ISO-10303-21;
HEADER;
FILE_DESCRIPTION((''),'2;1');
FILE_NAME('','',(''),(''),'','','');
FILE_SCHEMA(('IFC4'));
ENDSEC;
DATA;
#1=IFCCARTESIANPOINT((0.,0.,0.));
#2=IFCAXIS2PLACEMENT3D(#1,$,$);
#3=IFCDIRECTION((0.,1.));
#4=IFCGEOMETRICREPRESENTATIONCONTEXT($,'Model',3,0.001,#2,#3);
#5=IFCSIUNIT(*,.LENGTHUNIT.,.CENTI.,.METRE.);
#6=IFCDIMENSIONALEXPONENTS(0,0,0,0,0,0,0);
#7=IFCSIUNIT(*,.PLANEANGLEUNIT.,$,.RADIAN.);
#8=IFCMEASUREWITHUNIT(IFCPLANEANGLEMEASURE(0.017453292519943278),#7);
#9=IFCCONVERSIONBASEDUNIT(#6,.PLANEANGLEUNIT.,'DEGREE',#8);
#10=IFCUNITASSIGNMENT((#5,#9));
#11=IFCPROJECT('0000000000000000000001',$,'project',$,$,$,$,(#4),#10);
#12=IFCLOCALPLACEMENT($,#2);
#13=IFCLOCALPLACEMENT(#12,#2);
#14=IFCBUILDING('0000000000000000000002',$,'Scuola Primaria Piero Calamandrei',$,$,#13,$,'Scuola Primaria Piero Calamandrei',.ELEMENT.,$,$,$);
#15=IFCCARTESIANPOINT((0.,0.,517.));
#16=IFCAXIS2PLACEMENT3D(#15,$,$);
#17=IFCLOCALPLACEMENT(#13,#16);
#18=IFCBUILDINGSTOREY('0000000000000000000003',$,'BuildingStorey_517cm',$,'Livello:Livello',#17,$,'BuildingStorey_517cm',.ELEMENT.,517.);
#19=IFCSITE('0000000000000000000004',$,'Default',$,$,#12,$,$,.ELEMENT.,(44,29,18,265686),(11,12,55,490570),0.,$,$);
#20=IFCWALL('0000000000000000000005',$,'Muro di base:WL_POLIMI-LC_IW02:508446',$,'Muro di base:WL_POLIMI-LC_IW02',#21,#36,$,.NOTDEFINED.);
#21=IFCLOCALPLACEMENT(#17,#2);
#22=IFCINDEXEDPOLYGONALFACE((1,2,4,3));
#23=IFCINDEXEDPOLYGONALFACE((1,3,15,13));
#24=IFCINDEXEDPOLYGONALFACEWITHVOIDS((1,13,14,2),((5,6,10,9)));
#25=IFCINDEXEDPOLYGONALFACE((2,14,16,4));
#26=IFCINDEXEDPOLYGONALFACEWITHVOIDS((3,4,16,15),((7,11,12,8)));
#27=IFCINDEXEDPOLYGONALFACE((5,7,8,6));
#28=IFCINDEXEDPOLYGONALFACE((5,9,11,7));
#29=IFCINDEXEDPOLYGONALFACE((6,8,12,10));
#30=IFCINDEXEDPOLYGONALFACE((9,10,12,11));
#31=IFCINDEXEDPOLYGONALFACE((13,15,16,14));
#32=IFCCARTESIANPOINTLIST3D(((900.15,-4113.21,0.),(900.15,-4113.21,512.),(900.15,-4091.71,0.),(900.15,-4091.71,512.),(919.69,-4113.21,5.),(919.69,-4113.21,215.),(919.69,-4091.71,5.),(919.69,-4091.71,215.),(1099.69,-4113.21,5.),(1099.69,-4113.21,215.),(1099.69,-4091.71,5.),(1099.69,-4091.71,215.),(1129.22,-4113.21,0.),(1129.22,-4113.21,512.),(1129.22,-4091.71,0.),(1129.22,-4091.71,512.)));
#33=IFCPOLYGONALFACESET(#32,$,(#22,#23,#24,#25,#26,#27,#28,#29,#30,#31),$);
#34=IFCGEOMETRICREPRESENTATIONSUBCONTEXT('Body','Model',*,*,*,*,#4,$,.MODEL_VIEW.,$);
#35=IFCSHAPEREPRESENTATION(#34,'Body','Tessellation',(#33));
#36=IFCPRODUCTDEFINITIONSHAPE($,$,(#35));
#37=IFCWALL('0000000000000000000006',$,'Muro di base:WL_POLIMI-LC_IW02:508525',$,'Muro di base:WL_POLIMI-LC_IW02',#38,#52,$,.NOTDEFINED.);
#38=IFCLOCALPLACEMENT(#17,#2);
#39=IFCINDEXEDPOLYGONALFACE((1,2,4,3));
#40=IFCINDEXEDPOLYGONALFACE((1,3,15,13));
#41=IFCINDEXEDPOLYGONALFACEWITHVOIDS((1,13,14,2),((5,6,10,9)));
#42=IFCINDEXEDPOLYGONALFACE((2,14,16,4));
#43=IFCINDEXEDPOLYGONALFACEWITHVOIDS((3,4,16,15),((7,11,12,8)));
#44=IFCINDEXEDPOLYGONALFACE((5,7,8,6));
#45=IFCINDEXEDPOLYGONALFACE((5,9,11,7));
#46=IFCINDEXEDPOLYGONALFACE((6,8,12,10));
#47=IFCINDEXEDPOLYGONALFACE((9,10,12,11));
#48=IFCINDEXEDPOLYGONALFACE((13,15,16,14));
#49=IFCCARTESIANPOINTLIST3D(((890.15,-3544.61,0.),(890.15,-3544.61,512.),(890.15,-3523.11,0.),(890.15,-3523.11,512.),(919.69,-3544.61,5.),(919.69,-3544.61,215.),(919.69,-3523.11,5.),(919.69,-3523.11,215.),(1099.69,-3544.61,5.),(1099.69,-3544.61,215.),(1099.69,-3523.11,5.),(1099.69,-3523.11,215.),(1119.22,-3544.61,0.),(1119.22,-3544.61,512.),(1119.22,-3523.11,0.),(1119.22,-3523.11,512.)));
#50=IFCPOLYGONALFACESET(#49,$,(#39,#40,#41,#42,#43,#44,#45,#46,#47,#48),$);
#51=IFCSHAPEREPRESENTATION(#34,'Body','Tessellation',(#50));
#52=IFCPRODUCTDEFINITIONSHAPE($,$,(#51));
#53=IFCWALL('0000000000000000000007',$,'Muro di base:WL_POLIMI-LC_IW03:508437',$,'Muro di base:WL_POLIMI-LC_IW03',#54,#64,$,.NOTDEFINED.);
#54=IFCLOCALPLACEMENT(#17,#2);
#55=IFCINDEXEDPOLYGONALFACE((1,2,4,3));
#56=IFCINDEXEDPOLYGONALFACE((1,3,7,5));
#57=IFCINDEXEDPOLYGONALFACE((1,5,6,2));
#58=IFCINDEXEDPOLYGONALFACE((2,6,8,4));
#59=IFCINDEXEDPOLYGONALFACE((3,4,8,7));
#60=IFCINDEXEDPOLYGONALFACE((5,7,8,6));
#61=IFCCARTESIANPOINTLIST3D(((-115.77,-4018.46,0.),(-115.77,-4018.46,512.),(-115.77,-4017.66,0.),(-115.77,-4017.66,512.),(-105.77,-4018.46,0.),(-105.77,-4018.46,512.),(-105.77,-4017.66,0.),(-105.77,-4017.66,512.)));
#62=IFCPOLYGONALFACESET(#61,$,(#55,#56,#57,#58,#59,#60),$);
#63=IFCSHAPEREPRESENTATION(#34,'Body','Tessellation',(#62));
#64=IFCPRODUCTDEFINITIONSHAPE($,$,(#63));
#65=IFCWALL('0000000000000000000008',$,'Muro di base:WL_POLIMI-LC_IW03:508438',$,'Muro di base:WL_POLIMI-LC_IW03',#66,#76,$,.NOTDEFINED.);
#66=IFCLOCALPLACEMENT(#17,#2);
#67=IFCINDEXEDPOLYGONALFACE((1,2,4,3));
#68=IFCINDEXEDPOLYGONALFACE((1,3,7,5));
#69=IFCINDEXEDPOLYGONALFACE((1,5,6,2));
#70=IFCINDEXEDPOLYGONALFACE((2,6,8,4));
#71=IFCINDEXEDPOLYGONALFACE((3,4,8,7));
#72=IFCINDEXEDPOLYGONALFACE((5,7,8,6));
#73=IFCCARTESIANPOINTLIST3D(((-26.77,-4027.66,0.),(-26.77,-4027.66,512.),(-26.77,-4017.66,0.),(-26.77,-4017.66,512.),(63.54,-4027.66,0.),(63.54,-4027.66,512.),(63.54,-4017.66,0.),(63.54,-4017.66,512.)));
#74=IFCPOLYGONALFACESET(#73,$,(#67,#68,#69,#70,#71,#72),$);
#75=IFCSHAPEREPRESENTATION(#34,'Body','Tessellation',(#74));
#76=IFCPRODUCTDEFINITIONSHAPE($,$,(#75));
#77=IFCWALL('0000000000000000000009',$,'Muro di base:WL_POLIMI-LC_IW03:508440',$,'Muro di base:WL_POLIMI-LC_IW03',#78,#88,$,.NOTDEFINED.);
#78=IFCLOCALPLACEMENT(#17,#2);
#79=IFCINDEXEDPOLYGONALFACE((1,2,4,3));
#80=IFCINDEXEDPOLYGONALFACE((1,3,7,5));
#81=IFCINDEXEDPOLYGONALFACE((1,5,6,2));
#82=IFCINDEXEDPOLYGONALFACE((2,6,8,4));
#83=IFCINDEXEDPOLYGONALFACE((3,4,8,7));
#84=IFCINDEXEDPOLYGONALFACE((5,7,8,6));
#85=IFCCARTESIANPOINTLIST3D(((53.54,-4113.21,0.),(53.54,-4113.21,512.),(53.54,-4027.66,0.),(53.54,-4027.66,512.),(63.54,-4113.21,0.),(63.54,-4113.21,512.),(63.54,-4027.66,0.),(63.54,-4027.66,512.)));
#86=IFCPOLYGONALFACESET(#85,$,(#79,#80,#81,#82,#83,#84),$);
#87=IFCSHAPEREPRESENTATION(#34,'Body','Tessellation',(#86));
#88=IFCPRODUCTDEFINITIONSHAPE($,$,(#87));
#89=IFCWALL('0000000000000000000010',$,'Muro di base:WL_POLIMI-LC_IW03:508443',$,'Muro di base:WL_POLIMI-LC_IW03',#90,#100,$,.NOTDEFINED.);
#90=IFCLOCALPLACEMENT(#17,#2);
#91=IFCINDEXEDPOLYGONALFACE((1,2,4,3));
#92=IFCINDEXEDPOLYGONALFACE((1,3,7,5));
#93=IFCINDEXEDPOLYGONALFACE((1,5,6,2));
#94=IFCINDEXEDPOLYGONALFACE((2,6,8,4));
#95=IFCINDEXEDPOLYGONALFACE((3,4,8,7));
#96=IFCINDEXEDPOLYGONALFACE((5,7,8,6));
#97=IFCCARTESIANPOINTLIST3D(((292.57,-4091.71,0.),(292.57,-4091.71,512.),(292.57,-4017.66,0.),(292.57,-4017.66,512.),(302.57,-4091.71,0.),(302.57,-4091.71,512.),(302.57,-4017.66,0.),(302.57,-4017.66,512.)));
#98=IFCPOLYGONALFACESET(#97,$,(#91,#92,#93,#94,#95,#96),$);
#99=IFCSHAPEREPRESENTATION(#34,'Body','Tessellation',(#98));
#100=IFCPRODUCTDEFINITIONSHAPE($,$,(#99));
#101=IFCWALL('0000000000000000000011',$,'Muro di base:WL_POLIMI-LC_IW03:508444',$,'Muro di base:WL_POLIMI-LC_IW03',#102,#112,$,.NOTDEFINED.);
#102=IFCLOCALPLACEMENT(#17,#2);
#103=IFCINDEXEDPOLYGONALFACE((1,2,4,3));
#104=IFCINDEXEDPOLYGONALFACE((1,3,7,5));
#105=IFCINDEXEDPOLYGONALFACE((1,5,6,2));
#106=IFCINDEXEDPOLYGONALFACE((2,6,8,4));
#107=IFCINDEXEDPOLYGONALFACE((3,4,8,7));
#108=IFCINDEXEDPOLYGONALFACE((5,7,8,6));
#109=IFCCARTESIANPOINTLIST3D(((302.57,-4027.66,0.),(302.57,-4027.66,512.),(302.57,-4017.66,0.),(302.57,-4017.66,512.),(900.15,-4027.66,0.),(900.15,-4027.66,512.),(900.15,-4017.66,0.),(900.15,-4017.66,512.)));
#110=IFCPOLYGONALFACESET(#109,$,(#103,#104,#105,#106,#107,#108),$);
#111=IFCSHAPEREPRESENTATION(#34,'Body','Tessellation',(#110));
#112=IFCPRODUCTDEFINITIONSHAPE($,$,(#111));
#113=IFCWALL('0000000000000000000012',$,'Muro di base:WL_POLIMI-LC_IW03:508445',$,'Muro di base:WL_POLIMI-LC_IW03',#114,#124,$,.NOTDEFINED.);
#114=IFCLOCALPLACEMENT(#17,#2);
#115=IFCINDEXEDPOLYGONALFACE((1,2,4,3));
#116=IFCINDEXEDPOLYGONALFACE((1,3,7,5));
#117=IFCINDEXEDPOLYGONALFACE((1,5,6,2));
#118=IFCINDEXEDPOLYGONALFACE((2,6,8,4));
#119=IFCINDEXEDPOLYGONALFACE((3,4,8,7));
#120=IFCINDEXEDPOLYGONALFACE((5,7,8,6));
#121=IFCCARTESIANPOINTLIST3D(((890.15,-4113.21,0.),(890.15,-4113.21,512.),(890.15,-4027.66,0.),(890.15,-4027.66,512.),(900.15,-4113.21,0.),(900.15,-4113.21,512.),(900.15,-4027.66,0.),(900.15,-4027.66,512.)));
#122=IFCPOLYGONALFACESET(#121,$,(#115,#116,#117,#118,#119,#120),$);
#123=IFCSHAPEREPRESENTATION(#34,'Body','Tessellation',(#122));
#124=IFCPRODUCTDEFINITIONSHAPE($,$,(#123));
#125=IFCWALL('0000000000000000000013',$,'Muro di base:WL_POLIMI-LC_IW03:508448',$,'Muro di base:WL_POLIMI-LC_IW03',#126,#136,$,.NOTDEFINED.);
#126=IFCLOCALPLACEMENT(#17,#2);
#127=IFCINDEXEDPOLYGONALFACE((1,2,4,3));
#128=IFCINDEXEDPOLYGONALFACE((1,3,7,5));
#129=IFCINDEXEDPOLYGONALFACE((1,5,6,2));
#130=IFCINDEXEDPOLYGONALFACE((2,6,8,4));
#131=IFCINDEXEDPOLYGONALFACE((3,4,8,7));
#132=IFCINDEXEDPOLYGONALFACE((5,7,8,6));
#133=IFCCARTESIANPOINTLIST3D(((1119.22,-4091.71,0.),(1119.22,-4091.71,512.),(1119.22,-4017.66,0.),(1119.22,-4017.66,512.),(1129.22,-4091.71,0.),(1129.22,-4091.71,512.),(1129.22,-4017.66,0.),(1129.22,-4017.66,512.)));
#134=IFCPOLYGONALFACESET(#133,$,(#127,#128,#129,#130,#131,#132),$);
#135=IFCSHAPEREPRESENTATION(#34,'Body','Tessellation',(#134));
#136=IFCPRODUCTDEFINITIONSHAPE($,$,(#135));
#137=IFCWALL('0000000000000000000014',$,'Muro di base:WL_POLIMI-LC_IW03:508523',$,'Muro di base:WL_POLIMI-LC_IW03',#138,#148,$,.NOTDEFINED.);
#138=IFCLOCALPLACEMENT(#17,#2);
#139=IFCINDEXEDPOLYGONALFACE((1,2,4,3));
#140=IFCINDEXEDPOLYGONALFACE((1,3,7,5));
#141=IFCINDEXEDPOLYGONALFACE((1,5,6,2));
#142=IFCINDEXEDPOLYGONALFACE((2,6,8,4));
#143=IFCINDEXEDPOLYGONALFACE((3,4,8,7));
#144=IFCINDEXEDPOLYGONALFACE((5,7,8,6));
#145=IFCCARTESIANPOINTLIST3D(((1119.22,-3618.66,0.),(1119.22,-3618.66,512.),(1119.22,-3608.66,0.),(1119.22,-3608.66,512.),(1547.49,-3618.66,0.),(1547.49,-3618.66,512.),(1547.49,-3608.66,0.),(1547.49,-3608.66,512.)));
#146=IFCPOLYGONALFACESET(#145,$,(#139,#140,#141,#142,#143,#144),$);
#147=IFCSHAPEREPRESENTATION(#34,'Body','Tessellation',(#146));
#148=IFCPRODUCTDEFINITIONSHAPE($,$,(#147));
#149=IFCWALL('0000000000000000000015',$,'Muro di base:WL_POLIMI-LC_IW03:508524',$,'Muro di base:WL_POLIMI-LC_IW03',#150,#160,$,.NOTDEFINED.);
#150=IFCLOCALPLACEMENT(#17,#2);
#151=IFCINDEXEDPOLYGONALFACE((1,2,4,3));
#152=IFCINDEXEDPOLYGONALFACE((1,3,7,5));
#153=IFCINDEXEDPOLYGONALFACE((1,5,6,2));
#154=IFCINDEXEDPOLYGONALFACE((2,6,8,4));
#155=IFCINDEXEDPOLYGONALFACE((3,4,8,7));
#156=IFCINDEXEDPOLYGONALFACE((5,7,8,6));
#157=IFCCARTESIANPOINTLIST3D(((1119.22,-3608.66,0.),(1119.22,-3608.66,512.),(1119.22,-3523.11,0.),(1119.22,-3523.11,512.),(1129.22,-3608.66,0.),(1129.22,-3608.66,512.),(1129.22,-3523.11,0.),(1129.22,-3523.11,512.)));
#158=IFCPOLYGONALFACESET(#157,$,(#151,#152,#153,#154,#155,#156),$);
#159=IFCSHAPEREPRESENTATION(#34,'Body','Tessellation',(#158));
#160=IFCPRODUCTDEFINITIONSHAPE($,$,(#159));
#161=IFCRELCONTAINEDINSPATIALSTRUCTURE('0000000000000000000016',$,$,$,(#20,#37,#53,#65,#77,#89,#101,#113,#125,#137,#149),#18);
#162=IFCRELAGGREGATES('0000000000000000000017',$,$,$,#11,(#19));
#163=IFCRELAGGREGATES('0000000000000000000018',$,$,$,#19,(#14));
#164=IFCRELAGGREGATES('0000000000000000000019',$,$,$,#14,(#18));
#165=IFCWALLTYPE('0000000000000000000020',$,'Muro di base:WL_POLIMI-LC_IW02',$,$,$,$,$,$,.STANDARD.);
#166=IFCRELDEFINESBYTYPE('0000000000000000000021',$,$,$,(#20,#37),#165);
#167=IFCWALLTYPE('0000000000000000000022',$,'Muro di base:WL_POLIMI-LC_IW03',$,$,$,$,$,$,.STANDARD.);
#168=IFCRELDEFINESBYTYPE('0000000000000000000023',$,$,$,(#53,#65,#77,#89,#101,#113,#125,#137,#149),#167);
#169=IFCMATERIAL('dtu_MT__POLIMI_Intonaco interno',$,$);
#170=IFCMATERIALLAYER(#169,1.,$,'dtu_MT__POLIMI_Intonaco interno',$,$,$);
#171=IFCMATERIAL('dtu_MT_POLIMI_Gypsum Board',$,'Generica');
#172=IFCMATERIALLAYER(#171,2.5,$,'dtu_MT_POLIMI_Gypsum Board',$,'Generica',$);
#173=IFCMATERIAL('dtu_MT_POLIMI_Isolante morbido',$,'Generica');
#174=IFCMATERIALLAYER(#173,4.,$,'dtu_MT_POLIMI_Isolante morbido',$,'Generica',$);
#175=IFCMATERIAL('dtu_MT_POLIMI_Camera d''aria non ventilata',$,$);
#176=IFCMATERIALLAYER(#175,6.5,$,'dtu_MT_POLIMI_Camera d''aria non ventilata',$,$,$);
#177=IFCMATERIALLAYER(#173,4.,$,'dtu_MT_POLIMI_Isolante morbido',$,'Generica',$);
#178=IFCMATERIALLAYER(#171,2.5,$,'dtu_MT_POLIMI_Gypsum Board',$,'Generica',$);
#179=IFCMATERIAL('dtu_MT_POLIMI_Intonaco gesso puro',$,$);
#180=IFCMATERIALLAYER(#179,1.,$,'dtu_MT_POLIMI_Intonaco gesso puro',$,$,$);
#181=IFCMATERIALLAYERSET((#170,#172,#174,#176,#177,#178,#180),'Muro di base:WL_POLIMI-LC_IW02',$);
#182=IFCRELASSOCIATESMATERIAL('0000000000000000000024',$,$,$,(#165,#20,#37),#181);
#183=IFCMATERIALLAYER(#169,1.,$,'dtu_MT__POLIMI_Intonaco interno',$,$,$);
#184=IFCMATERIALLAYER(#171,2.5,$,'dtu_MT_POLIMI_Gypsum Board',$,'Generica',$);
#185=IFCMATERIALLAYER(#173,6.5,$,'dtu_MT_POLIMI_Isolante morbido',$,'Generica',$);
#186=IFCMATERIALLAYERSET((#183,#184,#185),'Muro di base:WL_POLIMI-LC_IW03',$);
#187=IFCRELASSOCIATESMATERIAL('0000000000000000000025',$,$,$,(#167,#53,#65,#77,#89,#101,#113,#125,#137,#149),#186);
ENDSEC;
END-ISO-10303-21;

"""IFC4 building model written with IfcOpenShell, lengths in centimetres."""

from ifc_helpers import new_model, entity, si_unit, converted_unit, direction, frame, frame_2d, origin, place, context, subcontext, project, spatial, rectangle, extrude, material, layer, layer_set, layer_usage, type_object, element, save


model = new_model("IFC4")

# Units and contexts
model_context = context("Model", 3, precision=0.001, world=origin(), true_north=direction((0.0, 1.0)))
body_context = subcontext(model_context, "Body", "Model", "MODEL_VIEW")
ifc_project = project(units=[si_unit("LENGTHUNIT", "METRE", prefix="CENTI"), converted_unit("PLANEANGLEUNIT", "DEGREE", entity("IfcPlaneAngleMeasure", 0.017453292519943278), si_unit("PLANEANGLEUNIT", "RADIAN"), dimensions=[0, 0, 0, 0, 0, 0, 0])], contexts=[model_context])

# Site, building, storey
site_placement = place(None, origin())
site = spatial("IfcSite", under=ifc_project, at=site_placement, Name="Default", CompositionType="ELEMENT", RefLatitude=(44, 29, 18, 265686), RefLongitude=(11, 12, 55, 490570), RefElevation=0.0)
building_placement = place(site_placement, origin())
building = spatial("IfcBuilding", under=site, at=building_placement, Name="Scuola Primaria Piero Calamandrei", LongName="Scuola Primaria Piero Calamandrei", CompositionType="ELEMENT")
storey_placement = place(building_placement, frame((0.0, 0.0, 517.0)))
storey = spatial("IfcBuildingStorey", under=building, at=storey_placement, Name="BuildingStorey_517cm", ObjectType="Livello:Livello", LongName="BuildingStorey_517cm", CompositionType="ELEMENT", Elevation=517.0)

# Shared definitions
ifc_material_1 = material(Name="dtu_MT__POLIMI_Intonaco interno")

# Shared definitions
ifc_material_2 = material(Name="dtu_MT_POLIMI_Isolante morbido", Category="Generica")
ifc_material_3 = material(Name="dtu_MT_POLIMI_Gypsum Board", Category="Generica")

# Walls, openings
ifc_layer_1 = layer(ifc_material_1, 1.0, Name="dtu_MT__POLIMI_Intonaco interno")
ifc_layer_2 = layer(ifc_material_3, 2.5, Name="dtu_MT_POLIMI_Gypsum Board", Category="Generica")
ifc_layer_3 = layer(ifc_material_2, 4.0, Name="dtu_MT_POLIMI_Isolante morbido", Category="Generica")
ifc_material_4 = material(Name="dtu_MT_POLIMI_Camera d'aria non ventilata")
ifc_layer_4 = layer(ifc_material_4, 6.5, Name="dtu_MT_POLIMI_Camera d'aria non ventilata")
ifc_layer_5 = layer(ifc_material_2, 4.0, Name="dtu_MT_POLIMI_Isolante morbido", Category="Generica")
ifc_layer_6 = layer(ifc_material_3, 2.5, Name="dtu_MT_POLIMI_Gypsum Board", Category="Generica")
ifc_material_5 = material(Name="dtu_MT_POLIMI_Intonaco gesso puro")
ifc_layer_7 = layer(ifc_material_5, 1.0, Name="dtu_MT_POLIMI_Intonaco gesso puro")
ifc_layer_set_1 = layer_set([ifc_layer_1, ifc_layer_2, ifc_layer_3, ifc_layer_4, ifc_layer_5, ifc_layer_6, ifc_layer_7], Name="Muro di base:WL_POLIMI-LC_IW02")
wall_type_1 = type_object("IfcWallType", Name="Muro di base:WL_POLIMI-LC_IW02", PredefinedType="STANDARD", material=ifc_layer_set_1)
ifc_layer_usage_1 = layer_usage(ifc_layer_set_1, "AXIS2", "NEGATIVE", 10.75)
wall_1_placement = place(storey_placement, frame((1129.22, -4102.46, 0.0), z_axis=(0.0, 0.0, 1.0), x_axis=(-1.0, 0.0, 0.0)))
wall_1 = element("IfcWall", 1, at=wall_1_placement, inside=storey, type_object=wall_type_1, material=ifc_layer_usage_1, Name="Muro di base:WL_POLIMI-LC_IW02:508446", ObjectType="Muro di base:WL_POLIMI-LC_IW02", PredefinedType="NOTDEFINED", context=body_context, shape_type="SweptSolid", body=[
    extrude(rectangle(XDim=229.07, YDim=21.5, at=frame_2d((114.54, 0.0), x_axis=(-1.0, 0.0))), origin(), (0.0, 0.0, 1.0), 512.0),
])
opening_1_placement = place(wall_1_placement, frame((209.54, 10.75, 5.0)))
element("IfcOpeningElement", 2, at=opening_1_placement, cuts=wall_1, PredefinedType="OPENING", context=body_context, shape_type="SweptSolid", body=[
    extrude(rectangle(XDim=210.0, YDim=180.0, at=frame_2d((105.0, 90.0), x_axis=(-1.0, 0.0))), frame((0.0, 0.0, 0.0), z_axis=(0.0, -1.0, 0.0), x_axis=(0.0, 0.0, 1.0)), (0.0, 0.0, 1.0), 21.5),
])
ifc_layer_usage_2 = layer_usage(ifc_layer_set_1, "AXIS2", "NEGATIVE", 10.75)
wall_2_placement = place(storey_placement, frame((890.15, -3533.86, 0.0)))
wall_2 = element("IfcWall", 3, at=wall_2_placement, inside=storey, type_object=wall_type_1, material=ifc_layer_usage_2, Name="Muro di base:WL_POLIMI-LC_IW02:508525", ObjectType="Muro di base:WL_POLIMI-LC_IW02", PredefinedType="NOTDEFINED", context=body_context, shape_type="SweptSolid", body=[
    extrude(rectangle(XDim=229.07, YDim=21.5, at=frame_2d((114.54, 0.0), x_axis=(-1.0, 0.0))), origin(), (0.0, 0.0, 1.0), 512.0),
])
opening_2_placement = place(wall_2_placement, frame((209.54, 10.75, 5.0)))
element("IfcOpeningElement", 4, at=opening_2_placement, cuts=wall_2, PredefinedType="OPENING", context=body_context, shape_type="SweptSolid", body=[
    extrude(rectangle(XDim=210.0, YDim=180.0, at=frame_2d((105.0, 90.0), x_axis=(-1.0, 0.0))), frame((0.0, 0.0, 0.0), z_axis=(0.0, -1.0, 0.0), x_axis=(0.0, 0.0, 1.0)), (0.0, 0.0, 1.0), 21.5),
])

# Walls
ifc_layer_8 = layer(ifc_material_1, 1.0, Name="dtu_MT__POLIMI_Intonaco interno")
ifc_layer_9 = layer(ifc_material_3, 2.5, Name="dtu_MT_POLIMI_Gypsum Board", Category="Generica")
ifc_layer_10 = layer(ifc_material_2, 6.5, Name="dtu_MT_POLIMI_Isolante morbido", Category="Generica")
ifc_layer_set_2 = layer_set([ifc_layer_8, ifc_layer_9, ifc_layer_10], Name="Muro di base:WL_POLIMI-LC_IW03")
ifc_layer_usage_3 = layer_usage(ifc_layer_set_2, "AXIS2", "NEGATIVE", 5.0)
wall_type_2 = type_object("IfcWallType", Name="Muro di base:WL_POLIMI-LC_IW03", PredefinedType="STANDARD", material=ifc_layer_set_2)
wall_3_placement = place(storey_placement, frame((-110.77, -4017.66, 0.0), z_axis=(0.0, 0.0, 1.0), x_axis=(0.0, -1.0, 0.0)))
element("IfcWall", 5, at=wall_3_placement, inside=storey, type_object=wall_type_2, material=ifc_layer_usage_3, Name="Muro di base:WL_POLIMI-LC_IW03:508437", ObjectType="Muro di base:WL_POLIMI-LC_IW03", PredefinedType="NOTDEFINED", context=body_context, shape_type="SweptSolid", body=[
    extrude(rectangle(XDim=0.8, YDim=10.0, at=frame_2d((0.4, 0.0), x_axis=(-1.0, 0.0))), origin(), (0.0, 0.0, 1.0), 512.0),
])
ifc_layer_usage_4 = layer_usage(ifc_layer_set_2, "AXIS2", "NEGATIVE", 5.0)
wall_4_placement = place(storey_placement, frame((63.54, -4022.66, 0.0), z_axis=(0.0, 0.0, 1.0), x_axis=(-1.0, 0.0, 0.0)))
element("IfcWall", 6, at=wall_4_placement, inside=storey, type_object=wall_type_2, material=ifc_layer_usage_4, Name="Muro di base:WL_POLIMI-LC_IW03:508438", ObjectType="Muro di base:WL_POLIMI-LC_IW03", PredefinedType="NOTDEFINED", context=body_context, shape_type="SweptSolid", body=[
    extrude(rectangle(XDim=10.0, YDim=90.31, at=frame_2d((-1.0, -7.03), x_axis=(1.0, 0.0))), frame((38.13, 1.0, 0.0), z_axis=(0.0, 0.0, 1.0), x_axis=(0.0, 1.0, 0.0)), (0.0, 0.0, 1.0), 512.0),
])
ifc_layer_usage_5 = layer_usage(ifc_layer_set_2, "AXIS2", "NEGATIVE", 5.0)
wall_5_placement = place(storey_placement, frame((58.54, -4113.21, 0.0), z_axis=(0.0, 0.0, 1.0), x_axis=(0.0, 1.0, 0.0)))
element("IfcWall", 7, at=wall_5_placement, inside=storey, type_object=wall_type_2, material=ifc_layer_usage_5, Name="Muro di base:WL_POLIMI-LC_IW03:508440", ObjectType="Muro di base:WL_POLIMI-LC_IW03", PredefinedType="NOTDEFINED", context=body_context, shape_type="SweptSolid", body=[
    extrude(rectangle(XDim=85.55, YDim=10.0, at=frame_2d((42.78, 0.0), x_axis=(-1.0, 0.0))), origin(), (0.0, 0.0, 1.0), 512.0),
])
ifc_layer_usage_6 = layer_usage(ifc_layer_set_2, "AXIS2", "NEGATIVE", 5.0)
wall_6_placement = place(storey_placement, frame((297.57, -4017.66, 0.0), z_axis=(0.0, 0.0, 1.0), x_axis=(0.0, -1.0, 0.0)))
element("IfcWall", 8, at=wall_6_placement, inside=storey, type_object=wall_type_2, material=ifc_layer_usage_6, Name="Muro di base:WL_POLIMI-LC_IW03:508443", ObjectType="Muro di base:WL_POLIMI-LC_IW03", PredefinedType="NOTDEFINED", context=body_context, shape_type="SweptSolid", body=[
    extrude(rectangle(XDim=74.05, YDim=10.0, at=frame_2d((37.03, 0.0), x_axis=(-1.0, 0.0))), origin(), (0.0, 0.0, 1.0), 512.0),
])
ifc_layer_usage_7 = layer_usage(ifc_layer_set_2, "AXIS2", "NEGATIVE", 5.0)
wall_7_placement = place(storey_placement, frame((900.15, -4022.66, 0.0), z_axis=(0.0, 0.0, 1.0), x_axis=(-1.0, 0.0, 0.0)))
element("IfcWall", 9, at=wall_7_placement, inside=storey, type_object=wall_type_2, material=ifc_layer_usage_7, Name="Muro di base:WL_POLIMI-LC_IW03:508444", ObjectType="Muro di base:WL_POLIMI-LC_IW03", PredefinedType="NOTDEFINED", context=body_context, shape_type="SweptSolid", body=[
    extrude(rectangle(XDim=597.58, YDim=10.0, at=frame_2d((298.79, 0.0), x_axis=(-1.0, 0.0))), origin(), (0.0, 0.0, 1.0), 512.0),
])
ifc_layer_usage_8 = layer_usage(ifc_layer_set_2, "AXIS2", "NEGATIVE", 5.0)
wall_8_placement = place(storey_placement, frame((895.15, -4113.21, 0.0), z_axis=(0.0, 0.0, 1.0), x_axis=(0.0, 1.0, 0.0)))
element("IfcWall", 10, at=wall_8_placement, inside=storey, type_object=wall_type_2, material=ifc_layer_usage_8, Name="Muro di base:WL_POLIMI-LC_IW03:508445", ObjectType="Muro di base:WL_POLIMI-LC_IW03", PredefinedType="NOTDEFINED", context=body_context, shape_type="SweptSolid", body=[
    extrude(rectangle(XDim=85.55, YDim=10.0, at=frame_2d((42.78, 0.0), x_axis=(-1.0, 0.0))), origin(), (0.0, 0.0, 1.0), 512.0),
])
ifc_layer_usage_9 = layer_usage(ifc_layer_set_2, "AXIS2", "NEGATIVE", 5.0)
wall_9_placement = place(storey_placement, frame((1124.22, -4017.66, 0.0), z_axis=(0.0, 0.0, 1.0), x_axis=(0.0, -1.0, 0.0)))
element("IfcWall", 11, at=wall_9_placement, inside=storey, type_object=wall_type_2, material=ifc_layer_usage_9, Name="Muro di base:WL_POLIMI-LC_IW03:508448", ObjectType="Muro di base:WL_POLIMI-LC_IW03", PredefinedType="NOTDEFINED", context=body_context, shape_type="SweptSolid", body=[
    extrude(rectangle(XDim=74.05, YDim=10.0, at=frame_2d((37.03, 0.0), x_axis=(-1.0, 0.0))), origin(), (0.0, 0.0, 1.0), 512.0),
])
ifc_layer_usage_10 = layer_usage(ifc_layer_set_2, "AXIS2", "NEGATIVE", 5.0)
wall_10_placement = place(storey_placement, frame((1119.22, -3613.66, 0.0)))
element("IfcWall", 12, at=wall_10_placement, inside=storey, type_object=wall_type_2, material=ifc_layer_usage_10, Name="Muro di base:WL_POLIMI-LC_IW03:508523", ObjectType="Muro di base:WL_POLIMI-LC_IW03", PredefinedType="NOTDEFINED", context=body_context, shape_type="SweptSolid", body=[
    extrude(rectangle(XDim=428.26, YDim=10.0, at=frame_2d((214.13, 0.0), x_axis=(-1.0, 0.0))), origin(), (0.0, 0.0, 1.0), 512.0),
])
ifc_layer_usage_11 = layer_usage(ifc_layer_set_2, "AXIS2", "NEGATIVE", 5.0)
wall_11_placement = place(storey_placement, frame((1124.22, -3523.11, 0.0), z_axis=(0.0, 0.0, 1.0), x_axis=(0.0, -1.0, 0.0)))
element("IfcWall", 13, at=wall_11_placement, inside=storey, type_object=wall_type_2, material=ifc_layer_usage_11, Name="Muro di base:WL_POLIMI-LC_IW03:508524", ObjectType="Muro di base:WL_POLIMI-LC_IW03", PredefinedType="NOTDEFINED", context=body_context, shape_type="SweptSolid", body=[
    extrude(rectangle(XDim=85.55, YDim=10.0, at=frame_2d((42.78, 0.0), x_axis=(-1.0, 0.0))), origin(), (0.0, 0.0, 1.0), 512.0),
])

save(model, "model.ifc")
